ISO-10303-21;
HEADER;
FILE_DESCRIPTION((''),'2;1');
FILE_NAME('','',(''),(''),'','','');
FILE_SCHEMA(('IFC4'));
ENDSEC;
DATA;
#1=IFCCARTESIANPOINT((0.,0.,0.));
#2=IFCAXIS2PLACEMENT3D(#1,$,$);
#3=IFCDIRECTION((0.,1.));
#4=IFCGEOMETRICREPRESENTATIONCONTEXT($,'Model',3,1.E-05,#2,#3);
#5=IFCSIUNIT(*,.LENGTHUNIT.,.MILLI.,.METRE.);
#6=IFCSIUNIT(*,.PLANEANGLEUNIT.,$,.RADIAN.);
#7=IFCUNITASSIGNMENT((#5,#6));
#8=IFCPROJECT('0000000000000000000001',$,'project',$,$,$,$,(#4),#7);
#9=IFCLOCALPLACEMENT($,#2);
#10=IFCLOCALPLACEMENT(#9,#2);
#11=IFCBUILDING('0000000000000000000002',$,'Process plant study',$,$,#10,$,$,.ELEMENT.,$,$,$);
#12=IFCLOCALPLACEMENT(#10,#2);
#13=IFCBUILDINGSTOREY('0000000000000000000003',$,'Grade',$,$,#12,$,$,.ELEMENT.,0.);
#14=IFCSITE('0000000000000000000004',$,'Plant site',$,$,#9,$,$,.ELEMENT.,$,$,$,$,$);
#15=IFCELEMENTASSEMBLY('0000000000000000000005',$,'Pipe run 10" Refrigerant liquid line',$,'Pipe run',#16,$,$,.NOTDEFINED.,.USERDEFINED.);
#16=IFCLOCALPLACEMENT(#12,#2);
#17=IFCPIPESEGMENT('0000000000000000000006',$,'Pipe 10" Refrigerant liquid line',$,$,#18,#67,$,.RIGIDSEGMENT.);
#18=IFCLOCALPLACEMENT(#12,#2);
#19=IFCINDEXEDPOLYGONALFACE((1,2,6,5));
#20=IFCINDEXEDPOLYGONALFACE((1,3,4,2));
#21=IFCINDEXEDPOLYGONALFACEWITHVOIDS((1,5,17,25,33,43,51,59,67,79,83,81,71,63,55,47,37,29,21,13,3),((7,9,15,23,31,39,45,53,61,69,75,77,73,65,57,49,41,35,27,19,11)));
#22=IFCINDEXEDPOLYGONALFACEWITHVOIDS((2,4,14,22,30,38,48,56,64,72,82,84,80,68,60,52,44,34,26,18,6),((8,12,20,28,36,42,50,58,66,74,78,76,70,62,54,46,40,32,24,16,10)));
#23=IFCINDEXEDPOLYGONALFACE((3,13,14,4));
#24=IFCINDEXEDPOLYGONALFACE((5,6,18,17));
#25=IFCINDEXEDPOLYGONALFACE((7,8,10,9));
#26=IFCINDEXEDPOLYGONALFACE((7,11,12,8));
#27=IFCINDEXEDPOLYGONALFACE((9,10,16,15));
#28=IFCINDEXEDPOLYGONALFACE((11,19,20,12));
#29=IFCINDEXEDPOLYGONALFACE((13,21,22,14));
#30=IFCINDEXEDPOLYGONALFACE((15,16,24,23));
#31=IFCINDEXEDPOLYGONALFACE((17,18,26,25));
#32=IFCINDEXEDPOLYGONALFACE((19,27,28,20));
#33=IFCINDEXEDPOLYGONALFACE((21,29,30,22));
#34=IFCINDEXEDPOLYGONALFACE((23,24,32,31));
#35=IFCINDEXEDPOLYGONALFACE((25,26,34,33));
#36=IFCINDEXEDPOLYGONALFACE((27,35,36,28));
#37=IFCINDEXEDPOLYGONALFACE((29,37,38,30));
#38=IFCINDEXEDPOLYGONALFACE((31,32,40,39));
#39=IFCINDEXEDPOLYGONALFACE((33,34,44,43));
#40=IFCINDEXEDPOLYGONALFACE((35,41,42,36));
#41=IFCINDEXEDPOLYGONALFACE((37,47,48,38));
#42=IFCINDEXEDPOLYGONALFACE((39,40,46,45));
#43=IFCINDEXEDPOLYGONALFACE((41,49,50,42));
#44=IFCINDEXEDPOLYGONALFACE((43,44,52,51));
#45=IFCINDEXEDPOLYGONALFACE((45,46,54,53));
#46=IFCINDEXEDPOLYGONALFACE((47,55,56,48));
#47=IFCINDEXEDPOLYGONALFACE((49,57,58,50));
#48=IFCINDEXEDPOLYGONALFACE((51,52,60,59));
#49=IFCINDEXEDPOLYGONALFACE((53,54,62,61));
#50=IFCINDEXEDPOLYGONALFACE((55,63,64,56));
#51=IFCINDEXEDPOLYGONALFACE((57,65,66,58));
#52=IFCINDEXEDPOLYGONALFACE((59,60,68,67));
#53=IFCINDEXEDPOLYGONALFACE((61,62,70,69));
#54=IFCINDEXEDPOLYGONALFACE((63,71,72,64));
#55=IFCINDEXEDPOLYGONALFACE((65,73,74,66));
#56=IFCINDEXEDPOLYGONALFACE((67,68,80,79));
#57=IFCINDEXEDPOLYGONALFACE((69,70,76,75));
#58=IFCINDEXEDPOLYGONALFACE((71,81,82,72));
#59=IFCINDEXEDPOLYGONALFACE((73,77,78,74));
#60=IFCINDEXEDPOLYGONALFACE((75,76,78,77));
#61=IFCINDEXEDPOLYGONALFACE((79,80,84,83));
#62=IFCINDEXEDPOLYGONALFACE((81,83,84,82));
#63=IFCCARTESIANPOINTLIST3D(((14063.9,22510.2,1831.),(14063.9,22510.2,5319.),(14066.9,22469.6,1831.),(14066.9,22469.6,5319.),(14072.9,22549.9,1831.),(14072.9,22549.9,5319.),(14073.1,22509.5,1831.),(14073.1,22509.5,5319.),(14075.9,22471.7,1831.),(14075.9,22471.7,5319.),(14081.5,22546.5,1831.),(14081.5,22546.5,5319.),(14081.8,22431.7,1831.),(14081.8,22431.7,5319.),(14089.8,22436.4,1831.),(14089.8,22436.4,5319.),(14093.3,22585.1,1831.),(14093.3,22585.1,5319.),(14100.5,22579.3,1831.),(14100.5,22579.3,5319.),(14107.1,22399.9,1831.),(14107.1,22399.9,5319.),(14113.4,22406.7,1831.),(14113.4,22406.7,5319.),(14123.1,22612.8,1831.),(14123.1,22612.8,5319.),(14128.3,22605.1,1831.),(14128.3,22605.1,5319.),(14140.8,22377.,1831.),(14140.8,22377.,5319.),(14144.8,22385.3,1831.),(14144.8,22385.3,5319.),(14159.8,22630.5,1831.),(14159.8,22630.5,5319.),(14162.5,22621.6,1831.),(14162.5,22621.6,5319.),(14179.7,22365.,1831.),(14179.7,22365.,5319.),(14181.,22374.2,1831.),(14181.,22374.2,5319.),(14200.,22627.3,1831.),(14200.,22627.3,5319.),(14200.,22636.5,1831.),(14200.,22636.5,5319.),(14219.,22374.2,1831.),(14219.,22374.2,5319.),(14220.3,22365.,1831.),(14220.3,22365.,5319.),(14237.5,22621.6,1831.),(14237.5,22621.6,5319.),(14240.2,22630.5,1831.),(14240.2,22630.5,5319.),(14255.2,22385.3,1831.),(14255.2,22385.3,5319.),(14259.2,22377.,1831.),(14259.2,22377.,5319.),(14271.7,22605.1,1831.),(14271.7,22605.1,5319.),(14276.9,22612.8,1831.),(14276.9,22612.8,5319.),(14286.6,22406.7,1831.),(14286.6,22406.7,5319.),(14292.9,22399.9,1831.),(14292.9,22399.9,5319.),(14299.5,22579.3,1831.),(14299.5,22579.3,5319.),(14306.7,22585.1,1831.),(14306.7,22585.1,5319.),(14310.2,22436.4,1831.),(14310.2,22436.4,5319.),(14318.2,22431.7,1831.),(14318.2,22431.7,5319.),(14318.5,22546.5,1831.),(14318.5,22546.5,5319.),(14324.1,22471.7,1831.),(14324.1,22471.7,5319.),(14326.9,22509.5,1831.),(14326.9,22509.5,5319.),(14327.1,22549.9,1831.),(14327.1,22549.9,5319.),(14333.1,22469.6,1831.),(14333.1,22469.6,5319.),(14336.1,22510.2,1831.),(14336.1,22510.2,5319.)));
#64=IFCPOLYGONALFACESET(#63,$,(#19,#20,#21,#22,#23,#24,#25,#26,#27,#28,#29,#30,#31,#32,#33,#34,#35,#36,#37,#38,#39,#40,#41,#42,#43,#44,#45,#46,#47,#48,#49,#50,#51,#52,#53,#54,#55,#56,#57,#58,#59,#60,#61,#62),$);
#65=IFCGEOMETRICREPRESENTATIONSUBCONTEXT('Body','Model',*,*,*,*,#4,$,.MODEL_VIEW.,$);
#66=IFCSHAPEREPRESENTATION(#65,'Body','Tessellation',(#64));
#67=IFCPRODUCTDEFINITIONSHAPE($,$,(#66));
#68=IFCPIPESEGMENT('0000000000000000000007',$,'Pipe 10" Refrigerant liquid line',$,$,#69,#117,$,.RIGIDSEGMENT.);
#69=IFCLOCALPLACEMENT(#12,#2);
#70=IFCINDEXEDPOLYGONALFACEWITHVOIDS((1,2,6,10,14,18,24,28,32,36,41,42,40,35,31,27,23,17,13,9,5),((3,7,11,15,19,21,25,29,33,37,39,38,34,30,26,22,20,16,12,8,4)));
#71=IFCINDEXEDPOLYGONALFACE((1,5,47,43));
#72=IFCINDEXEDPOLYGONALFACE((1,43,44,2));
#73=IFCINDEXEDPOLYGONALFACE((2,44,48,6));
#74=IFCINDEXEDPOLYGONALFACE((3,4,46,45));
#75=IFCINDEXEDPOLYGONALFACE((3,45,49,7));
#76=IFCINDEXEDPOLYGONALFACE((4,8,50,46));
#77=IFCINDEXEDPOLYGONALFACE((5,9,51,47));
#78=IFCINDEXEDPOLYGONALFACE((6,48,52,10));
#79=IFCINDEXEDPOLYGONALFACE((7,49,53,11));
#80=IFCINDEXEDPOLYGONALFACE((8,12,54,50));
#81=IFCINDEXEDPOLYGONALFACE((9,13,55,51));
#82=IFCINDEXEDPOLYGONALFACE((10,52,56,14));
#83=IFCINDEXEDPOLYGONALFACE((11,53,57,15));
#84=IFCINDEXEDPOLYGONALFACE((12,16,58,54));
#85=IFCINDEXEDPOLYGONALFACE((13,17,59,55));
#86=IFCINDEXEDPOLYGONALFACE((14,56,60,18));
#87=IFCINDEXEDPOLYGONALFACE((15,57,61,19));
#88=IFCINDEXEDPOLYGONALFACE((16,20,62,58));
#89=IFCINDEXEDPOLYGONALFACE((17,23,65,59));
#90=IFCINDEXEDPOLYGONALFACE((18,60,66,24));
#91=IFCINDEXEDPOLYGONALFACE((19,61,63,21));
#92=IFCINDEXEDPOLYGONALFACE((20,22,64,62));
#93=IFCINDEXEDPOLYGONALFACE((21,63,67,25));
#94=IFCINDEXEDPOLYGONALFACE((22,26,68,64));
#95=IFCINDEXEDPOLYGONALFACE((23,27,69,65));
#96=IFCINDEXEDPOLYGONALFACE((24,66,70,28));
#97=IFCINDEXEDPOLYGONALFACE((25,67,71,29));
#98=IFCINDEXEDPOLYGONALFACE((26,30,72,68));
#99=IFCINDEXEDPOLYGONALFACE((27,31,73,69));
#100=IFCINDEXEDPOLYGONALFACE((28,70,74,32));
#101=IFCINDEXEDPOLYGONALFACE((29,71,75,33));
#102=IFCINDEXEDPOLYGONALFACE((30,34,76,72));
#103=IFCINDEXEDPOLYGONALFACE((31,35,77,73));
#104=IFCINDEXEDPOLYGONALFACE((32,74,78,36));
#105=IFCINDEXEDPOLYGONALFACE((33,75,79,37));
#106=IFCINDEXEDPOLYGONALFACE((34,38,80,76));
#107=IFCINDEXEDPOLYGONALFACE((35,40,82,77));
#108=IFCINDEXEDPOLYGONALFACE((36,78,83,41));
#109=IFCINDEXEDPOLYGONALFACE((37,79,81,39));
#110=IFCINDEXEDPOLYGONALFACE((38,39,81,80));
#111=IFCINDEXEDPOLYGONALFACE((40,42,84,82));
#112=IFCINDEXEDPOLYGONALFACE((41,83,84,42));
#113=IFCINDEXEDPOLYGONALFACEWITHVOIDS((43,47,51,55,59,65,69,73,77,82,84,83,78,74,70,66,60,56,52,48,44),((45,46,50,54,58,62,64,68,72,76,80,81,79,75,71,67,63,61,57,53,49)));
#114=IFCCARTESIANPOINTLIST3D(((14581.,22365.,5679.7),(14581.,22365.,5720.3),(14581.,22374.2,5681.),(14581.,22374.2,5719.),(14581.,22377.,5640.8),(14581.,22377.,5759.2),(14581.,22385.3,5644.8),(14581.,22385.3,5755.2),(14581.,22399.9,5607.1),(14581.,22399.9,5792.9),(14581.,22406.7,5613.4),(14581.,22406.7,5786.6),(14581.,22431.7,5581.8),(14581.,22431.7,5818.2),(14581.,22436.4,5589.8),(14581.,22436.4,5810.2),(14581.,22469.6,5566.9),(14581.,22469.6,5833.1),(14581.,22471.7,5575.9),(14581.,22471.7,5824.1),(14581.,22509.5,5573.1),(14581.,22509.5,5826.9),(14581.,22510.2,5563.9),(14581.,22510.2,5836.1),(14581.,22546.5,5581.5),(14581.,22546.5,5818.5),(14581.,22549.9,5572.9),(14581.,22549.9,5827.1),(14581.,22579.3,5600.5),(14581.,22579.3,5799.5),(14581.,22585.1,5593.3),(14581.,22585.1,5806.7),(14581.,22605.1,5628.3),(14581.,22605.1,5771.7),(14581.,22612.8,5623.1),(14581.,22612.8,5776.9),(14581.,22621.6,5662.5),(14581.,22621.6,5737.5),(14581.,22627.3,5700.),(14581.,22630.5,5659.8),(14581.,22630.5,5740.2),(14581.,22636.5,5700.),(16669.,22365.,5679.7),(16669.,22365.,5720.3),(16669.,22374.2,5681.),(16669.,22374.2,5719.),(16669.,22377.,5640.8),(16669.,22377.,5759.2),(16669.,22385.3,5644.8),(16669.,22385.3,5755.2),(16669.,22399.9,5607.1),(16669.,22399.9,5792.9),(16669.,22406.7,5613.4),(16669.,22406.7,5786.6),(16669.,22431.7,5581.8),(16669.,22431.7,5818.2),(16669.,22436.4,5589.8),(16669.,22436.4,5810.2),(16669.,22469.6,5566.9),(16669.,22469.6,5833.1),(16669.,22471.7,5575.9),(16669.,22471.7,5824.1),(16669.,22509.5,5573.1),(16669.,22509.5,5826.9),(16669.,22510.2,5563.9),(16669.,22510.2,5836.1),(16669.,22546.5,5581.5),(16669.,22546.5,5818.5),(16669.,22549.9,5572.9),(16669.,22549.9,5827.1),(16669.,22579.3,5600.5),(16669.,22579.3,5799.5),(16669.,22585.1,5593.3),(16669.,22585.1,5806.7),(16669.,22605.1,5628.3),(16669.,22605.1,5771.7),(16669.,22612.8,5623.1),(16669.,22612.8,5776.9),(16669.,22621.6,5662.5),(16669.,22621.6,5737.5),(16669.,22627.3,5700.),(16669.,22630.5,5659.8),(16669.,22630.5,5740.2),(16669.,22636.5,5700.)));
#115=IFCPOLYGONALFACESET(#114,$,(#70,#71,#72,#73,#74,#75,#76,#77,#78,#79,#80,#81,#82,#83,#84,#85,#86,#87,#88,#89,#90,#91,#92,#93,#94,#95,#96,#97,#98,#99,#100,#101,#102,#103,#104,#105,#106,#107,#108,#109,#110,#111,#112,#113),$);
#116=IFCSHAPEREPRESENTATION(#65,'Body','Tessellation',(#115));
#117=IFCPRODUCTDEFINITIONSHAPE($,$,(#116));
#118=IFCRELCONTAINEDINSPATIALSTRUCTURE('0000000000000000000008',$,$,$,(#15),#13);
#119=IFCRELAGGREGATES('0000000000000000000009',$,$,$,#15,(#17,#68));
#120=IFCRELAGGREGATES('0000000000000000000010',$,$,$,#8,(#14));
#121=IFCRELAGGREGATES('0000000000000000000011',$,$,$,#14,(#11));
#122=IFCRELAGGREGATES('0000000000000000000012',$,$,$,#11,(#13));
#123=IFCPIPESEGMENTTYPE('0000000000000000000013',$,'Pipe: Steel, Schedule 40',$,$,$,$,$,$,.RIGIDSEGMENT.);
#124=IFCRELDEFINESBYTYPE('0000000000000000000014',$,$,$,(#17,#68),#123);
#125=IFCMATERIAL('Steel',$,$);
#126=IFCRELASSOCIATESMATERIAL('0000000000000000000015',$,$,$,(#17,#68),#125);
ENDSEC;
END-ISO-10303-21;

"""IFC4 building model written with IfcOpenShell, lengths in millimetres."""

from ifc_helpers import new_model, si_unit, direction, frame, origin, origin_with_axes, origin_2d, place, context, subcontext, project, spatial, hollow_circle, extrude, material, type_object, element, aggregate, save


model = new_model("IFC4")

# Units and contexts
model_context = context("Model", 3, precision=1e-05, world=origin(), true_north=direction((0.0, 1.0)))
body_context = subcontext(model_context, "Body", "Model", "MODEL_VIEW")
ifc_project = project(units=[si_unit("LENGTHUNIT", "METRE", prefix="MILLI"), si_unit("PLANEANGLEUNIT", "RADIAN")], contexts=[model_context])

# Site, building, storey
site_placement = place(None, origin())
site = spatial("IfcSite", under=ifc_project, at=site_placement, Name="Plant site", CompositionType="ELEMENT")
building_placement = place(site_placement, origin())
building = spatial("IfcBuilding", under=site, at=building_placement, Name="Process plant study", CompositionType="ELEMENT")
storey_placement = place(building_placement, origin())
storey = spatial("IfcBuildingStorey", under=building, at=storey_placement, Name="Grade", CompositionType="ELEMENT", Elevation=0.0)

# Element assembly, pipe segments
ifc_material = material(Name="Steel")
pipe_segment_type = type_object("IfcPipeSegmentType", Name="Pipe: Steel, Schedule 40", PredefinedType="RIGIDSEGMENT")
assembly_1_placement = place(storey_placement, origin_with_axes())
assembly_1 = element("IfcElementAssembly", 1, at=assembly_1_placement, inside=storey, Name="Pipe run 10\" Refrigerant liquid line", ObjectType="Pipe run", AssemblyPlace="NOTDEFINED", PredefinedType="USERDEFINED")
pipe_segment_1_placement = place(storey_placement, origin_with_axes())
pipe_segment_1 = element("IfcPipeSegment", 2, at=pipe_segment_1_placement, type_object=pipe_segment_type, material=ifc_material, Name="Pipe 10\" Refrigerant liquid line", PredefinedType="RIGIDSEGMENT", context=body_context, shape_type="SweptSolid", body=[
    extrude(hollow_circle(Radius=136.5, WallThickness=9.3, at=origin_2d()), frame((14200.0, 22500.0, 1831.0), z_axis=(0.0, 0.0, 1.0), x_axis=(0.0, 1.0, 0.0)), (0.0, 0.0, 1.0), 3488.0),
])
pipe_segment_2_placement = place(storey_placement, origin_with_axes())
pipe_segment_2 = element("IfcPipeSegment", 3, at=pipe_segment_2_placement, type_object=pipe_segment_type, material=ifc_material, Name="Pipe 10\" Refrigerant liquid line", PredefinedType="RIGIDSEGMENT", context=body_context, shape_type="SweptSolid", body=[
    extrude(hollow_circle(Radius=136.5, WallThickness=9.3, at=origin_2d()), frame((14581.0, 22500.0, 5700.0), z_axis=(1.0, 0.0, 0.0), x_axis=(0.0, 1.0, 0.0)), (0.0, 0.0, 1.0), 2088.0),
])

aggregate(assembly_1, [pipe_segment_1, pipe_segment_2])

save(model, "model.ifc")
